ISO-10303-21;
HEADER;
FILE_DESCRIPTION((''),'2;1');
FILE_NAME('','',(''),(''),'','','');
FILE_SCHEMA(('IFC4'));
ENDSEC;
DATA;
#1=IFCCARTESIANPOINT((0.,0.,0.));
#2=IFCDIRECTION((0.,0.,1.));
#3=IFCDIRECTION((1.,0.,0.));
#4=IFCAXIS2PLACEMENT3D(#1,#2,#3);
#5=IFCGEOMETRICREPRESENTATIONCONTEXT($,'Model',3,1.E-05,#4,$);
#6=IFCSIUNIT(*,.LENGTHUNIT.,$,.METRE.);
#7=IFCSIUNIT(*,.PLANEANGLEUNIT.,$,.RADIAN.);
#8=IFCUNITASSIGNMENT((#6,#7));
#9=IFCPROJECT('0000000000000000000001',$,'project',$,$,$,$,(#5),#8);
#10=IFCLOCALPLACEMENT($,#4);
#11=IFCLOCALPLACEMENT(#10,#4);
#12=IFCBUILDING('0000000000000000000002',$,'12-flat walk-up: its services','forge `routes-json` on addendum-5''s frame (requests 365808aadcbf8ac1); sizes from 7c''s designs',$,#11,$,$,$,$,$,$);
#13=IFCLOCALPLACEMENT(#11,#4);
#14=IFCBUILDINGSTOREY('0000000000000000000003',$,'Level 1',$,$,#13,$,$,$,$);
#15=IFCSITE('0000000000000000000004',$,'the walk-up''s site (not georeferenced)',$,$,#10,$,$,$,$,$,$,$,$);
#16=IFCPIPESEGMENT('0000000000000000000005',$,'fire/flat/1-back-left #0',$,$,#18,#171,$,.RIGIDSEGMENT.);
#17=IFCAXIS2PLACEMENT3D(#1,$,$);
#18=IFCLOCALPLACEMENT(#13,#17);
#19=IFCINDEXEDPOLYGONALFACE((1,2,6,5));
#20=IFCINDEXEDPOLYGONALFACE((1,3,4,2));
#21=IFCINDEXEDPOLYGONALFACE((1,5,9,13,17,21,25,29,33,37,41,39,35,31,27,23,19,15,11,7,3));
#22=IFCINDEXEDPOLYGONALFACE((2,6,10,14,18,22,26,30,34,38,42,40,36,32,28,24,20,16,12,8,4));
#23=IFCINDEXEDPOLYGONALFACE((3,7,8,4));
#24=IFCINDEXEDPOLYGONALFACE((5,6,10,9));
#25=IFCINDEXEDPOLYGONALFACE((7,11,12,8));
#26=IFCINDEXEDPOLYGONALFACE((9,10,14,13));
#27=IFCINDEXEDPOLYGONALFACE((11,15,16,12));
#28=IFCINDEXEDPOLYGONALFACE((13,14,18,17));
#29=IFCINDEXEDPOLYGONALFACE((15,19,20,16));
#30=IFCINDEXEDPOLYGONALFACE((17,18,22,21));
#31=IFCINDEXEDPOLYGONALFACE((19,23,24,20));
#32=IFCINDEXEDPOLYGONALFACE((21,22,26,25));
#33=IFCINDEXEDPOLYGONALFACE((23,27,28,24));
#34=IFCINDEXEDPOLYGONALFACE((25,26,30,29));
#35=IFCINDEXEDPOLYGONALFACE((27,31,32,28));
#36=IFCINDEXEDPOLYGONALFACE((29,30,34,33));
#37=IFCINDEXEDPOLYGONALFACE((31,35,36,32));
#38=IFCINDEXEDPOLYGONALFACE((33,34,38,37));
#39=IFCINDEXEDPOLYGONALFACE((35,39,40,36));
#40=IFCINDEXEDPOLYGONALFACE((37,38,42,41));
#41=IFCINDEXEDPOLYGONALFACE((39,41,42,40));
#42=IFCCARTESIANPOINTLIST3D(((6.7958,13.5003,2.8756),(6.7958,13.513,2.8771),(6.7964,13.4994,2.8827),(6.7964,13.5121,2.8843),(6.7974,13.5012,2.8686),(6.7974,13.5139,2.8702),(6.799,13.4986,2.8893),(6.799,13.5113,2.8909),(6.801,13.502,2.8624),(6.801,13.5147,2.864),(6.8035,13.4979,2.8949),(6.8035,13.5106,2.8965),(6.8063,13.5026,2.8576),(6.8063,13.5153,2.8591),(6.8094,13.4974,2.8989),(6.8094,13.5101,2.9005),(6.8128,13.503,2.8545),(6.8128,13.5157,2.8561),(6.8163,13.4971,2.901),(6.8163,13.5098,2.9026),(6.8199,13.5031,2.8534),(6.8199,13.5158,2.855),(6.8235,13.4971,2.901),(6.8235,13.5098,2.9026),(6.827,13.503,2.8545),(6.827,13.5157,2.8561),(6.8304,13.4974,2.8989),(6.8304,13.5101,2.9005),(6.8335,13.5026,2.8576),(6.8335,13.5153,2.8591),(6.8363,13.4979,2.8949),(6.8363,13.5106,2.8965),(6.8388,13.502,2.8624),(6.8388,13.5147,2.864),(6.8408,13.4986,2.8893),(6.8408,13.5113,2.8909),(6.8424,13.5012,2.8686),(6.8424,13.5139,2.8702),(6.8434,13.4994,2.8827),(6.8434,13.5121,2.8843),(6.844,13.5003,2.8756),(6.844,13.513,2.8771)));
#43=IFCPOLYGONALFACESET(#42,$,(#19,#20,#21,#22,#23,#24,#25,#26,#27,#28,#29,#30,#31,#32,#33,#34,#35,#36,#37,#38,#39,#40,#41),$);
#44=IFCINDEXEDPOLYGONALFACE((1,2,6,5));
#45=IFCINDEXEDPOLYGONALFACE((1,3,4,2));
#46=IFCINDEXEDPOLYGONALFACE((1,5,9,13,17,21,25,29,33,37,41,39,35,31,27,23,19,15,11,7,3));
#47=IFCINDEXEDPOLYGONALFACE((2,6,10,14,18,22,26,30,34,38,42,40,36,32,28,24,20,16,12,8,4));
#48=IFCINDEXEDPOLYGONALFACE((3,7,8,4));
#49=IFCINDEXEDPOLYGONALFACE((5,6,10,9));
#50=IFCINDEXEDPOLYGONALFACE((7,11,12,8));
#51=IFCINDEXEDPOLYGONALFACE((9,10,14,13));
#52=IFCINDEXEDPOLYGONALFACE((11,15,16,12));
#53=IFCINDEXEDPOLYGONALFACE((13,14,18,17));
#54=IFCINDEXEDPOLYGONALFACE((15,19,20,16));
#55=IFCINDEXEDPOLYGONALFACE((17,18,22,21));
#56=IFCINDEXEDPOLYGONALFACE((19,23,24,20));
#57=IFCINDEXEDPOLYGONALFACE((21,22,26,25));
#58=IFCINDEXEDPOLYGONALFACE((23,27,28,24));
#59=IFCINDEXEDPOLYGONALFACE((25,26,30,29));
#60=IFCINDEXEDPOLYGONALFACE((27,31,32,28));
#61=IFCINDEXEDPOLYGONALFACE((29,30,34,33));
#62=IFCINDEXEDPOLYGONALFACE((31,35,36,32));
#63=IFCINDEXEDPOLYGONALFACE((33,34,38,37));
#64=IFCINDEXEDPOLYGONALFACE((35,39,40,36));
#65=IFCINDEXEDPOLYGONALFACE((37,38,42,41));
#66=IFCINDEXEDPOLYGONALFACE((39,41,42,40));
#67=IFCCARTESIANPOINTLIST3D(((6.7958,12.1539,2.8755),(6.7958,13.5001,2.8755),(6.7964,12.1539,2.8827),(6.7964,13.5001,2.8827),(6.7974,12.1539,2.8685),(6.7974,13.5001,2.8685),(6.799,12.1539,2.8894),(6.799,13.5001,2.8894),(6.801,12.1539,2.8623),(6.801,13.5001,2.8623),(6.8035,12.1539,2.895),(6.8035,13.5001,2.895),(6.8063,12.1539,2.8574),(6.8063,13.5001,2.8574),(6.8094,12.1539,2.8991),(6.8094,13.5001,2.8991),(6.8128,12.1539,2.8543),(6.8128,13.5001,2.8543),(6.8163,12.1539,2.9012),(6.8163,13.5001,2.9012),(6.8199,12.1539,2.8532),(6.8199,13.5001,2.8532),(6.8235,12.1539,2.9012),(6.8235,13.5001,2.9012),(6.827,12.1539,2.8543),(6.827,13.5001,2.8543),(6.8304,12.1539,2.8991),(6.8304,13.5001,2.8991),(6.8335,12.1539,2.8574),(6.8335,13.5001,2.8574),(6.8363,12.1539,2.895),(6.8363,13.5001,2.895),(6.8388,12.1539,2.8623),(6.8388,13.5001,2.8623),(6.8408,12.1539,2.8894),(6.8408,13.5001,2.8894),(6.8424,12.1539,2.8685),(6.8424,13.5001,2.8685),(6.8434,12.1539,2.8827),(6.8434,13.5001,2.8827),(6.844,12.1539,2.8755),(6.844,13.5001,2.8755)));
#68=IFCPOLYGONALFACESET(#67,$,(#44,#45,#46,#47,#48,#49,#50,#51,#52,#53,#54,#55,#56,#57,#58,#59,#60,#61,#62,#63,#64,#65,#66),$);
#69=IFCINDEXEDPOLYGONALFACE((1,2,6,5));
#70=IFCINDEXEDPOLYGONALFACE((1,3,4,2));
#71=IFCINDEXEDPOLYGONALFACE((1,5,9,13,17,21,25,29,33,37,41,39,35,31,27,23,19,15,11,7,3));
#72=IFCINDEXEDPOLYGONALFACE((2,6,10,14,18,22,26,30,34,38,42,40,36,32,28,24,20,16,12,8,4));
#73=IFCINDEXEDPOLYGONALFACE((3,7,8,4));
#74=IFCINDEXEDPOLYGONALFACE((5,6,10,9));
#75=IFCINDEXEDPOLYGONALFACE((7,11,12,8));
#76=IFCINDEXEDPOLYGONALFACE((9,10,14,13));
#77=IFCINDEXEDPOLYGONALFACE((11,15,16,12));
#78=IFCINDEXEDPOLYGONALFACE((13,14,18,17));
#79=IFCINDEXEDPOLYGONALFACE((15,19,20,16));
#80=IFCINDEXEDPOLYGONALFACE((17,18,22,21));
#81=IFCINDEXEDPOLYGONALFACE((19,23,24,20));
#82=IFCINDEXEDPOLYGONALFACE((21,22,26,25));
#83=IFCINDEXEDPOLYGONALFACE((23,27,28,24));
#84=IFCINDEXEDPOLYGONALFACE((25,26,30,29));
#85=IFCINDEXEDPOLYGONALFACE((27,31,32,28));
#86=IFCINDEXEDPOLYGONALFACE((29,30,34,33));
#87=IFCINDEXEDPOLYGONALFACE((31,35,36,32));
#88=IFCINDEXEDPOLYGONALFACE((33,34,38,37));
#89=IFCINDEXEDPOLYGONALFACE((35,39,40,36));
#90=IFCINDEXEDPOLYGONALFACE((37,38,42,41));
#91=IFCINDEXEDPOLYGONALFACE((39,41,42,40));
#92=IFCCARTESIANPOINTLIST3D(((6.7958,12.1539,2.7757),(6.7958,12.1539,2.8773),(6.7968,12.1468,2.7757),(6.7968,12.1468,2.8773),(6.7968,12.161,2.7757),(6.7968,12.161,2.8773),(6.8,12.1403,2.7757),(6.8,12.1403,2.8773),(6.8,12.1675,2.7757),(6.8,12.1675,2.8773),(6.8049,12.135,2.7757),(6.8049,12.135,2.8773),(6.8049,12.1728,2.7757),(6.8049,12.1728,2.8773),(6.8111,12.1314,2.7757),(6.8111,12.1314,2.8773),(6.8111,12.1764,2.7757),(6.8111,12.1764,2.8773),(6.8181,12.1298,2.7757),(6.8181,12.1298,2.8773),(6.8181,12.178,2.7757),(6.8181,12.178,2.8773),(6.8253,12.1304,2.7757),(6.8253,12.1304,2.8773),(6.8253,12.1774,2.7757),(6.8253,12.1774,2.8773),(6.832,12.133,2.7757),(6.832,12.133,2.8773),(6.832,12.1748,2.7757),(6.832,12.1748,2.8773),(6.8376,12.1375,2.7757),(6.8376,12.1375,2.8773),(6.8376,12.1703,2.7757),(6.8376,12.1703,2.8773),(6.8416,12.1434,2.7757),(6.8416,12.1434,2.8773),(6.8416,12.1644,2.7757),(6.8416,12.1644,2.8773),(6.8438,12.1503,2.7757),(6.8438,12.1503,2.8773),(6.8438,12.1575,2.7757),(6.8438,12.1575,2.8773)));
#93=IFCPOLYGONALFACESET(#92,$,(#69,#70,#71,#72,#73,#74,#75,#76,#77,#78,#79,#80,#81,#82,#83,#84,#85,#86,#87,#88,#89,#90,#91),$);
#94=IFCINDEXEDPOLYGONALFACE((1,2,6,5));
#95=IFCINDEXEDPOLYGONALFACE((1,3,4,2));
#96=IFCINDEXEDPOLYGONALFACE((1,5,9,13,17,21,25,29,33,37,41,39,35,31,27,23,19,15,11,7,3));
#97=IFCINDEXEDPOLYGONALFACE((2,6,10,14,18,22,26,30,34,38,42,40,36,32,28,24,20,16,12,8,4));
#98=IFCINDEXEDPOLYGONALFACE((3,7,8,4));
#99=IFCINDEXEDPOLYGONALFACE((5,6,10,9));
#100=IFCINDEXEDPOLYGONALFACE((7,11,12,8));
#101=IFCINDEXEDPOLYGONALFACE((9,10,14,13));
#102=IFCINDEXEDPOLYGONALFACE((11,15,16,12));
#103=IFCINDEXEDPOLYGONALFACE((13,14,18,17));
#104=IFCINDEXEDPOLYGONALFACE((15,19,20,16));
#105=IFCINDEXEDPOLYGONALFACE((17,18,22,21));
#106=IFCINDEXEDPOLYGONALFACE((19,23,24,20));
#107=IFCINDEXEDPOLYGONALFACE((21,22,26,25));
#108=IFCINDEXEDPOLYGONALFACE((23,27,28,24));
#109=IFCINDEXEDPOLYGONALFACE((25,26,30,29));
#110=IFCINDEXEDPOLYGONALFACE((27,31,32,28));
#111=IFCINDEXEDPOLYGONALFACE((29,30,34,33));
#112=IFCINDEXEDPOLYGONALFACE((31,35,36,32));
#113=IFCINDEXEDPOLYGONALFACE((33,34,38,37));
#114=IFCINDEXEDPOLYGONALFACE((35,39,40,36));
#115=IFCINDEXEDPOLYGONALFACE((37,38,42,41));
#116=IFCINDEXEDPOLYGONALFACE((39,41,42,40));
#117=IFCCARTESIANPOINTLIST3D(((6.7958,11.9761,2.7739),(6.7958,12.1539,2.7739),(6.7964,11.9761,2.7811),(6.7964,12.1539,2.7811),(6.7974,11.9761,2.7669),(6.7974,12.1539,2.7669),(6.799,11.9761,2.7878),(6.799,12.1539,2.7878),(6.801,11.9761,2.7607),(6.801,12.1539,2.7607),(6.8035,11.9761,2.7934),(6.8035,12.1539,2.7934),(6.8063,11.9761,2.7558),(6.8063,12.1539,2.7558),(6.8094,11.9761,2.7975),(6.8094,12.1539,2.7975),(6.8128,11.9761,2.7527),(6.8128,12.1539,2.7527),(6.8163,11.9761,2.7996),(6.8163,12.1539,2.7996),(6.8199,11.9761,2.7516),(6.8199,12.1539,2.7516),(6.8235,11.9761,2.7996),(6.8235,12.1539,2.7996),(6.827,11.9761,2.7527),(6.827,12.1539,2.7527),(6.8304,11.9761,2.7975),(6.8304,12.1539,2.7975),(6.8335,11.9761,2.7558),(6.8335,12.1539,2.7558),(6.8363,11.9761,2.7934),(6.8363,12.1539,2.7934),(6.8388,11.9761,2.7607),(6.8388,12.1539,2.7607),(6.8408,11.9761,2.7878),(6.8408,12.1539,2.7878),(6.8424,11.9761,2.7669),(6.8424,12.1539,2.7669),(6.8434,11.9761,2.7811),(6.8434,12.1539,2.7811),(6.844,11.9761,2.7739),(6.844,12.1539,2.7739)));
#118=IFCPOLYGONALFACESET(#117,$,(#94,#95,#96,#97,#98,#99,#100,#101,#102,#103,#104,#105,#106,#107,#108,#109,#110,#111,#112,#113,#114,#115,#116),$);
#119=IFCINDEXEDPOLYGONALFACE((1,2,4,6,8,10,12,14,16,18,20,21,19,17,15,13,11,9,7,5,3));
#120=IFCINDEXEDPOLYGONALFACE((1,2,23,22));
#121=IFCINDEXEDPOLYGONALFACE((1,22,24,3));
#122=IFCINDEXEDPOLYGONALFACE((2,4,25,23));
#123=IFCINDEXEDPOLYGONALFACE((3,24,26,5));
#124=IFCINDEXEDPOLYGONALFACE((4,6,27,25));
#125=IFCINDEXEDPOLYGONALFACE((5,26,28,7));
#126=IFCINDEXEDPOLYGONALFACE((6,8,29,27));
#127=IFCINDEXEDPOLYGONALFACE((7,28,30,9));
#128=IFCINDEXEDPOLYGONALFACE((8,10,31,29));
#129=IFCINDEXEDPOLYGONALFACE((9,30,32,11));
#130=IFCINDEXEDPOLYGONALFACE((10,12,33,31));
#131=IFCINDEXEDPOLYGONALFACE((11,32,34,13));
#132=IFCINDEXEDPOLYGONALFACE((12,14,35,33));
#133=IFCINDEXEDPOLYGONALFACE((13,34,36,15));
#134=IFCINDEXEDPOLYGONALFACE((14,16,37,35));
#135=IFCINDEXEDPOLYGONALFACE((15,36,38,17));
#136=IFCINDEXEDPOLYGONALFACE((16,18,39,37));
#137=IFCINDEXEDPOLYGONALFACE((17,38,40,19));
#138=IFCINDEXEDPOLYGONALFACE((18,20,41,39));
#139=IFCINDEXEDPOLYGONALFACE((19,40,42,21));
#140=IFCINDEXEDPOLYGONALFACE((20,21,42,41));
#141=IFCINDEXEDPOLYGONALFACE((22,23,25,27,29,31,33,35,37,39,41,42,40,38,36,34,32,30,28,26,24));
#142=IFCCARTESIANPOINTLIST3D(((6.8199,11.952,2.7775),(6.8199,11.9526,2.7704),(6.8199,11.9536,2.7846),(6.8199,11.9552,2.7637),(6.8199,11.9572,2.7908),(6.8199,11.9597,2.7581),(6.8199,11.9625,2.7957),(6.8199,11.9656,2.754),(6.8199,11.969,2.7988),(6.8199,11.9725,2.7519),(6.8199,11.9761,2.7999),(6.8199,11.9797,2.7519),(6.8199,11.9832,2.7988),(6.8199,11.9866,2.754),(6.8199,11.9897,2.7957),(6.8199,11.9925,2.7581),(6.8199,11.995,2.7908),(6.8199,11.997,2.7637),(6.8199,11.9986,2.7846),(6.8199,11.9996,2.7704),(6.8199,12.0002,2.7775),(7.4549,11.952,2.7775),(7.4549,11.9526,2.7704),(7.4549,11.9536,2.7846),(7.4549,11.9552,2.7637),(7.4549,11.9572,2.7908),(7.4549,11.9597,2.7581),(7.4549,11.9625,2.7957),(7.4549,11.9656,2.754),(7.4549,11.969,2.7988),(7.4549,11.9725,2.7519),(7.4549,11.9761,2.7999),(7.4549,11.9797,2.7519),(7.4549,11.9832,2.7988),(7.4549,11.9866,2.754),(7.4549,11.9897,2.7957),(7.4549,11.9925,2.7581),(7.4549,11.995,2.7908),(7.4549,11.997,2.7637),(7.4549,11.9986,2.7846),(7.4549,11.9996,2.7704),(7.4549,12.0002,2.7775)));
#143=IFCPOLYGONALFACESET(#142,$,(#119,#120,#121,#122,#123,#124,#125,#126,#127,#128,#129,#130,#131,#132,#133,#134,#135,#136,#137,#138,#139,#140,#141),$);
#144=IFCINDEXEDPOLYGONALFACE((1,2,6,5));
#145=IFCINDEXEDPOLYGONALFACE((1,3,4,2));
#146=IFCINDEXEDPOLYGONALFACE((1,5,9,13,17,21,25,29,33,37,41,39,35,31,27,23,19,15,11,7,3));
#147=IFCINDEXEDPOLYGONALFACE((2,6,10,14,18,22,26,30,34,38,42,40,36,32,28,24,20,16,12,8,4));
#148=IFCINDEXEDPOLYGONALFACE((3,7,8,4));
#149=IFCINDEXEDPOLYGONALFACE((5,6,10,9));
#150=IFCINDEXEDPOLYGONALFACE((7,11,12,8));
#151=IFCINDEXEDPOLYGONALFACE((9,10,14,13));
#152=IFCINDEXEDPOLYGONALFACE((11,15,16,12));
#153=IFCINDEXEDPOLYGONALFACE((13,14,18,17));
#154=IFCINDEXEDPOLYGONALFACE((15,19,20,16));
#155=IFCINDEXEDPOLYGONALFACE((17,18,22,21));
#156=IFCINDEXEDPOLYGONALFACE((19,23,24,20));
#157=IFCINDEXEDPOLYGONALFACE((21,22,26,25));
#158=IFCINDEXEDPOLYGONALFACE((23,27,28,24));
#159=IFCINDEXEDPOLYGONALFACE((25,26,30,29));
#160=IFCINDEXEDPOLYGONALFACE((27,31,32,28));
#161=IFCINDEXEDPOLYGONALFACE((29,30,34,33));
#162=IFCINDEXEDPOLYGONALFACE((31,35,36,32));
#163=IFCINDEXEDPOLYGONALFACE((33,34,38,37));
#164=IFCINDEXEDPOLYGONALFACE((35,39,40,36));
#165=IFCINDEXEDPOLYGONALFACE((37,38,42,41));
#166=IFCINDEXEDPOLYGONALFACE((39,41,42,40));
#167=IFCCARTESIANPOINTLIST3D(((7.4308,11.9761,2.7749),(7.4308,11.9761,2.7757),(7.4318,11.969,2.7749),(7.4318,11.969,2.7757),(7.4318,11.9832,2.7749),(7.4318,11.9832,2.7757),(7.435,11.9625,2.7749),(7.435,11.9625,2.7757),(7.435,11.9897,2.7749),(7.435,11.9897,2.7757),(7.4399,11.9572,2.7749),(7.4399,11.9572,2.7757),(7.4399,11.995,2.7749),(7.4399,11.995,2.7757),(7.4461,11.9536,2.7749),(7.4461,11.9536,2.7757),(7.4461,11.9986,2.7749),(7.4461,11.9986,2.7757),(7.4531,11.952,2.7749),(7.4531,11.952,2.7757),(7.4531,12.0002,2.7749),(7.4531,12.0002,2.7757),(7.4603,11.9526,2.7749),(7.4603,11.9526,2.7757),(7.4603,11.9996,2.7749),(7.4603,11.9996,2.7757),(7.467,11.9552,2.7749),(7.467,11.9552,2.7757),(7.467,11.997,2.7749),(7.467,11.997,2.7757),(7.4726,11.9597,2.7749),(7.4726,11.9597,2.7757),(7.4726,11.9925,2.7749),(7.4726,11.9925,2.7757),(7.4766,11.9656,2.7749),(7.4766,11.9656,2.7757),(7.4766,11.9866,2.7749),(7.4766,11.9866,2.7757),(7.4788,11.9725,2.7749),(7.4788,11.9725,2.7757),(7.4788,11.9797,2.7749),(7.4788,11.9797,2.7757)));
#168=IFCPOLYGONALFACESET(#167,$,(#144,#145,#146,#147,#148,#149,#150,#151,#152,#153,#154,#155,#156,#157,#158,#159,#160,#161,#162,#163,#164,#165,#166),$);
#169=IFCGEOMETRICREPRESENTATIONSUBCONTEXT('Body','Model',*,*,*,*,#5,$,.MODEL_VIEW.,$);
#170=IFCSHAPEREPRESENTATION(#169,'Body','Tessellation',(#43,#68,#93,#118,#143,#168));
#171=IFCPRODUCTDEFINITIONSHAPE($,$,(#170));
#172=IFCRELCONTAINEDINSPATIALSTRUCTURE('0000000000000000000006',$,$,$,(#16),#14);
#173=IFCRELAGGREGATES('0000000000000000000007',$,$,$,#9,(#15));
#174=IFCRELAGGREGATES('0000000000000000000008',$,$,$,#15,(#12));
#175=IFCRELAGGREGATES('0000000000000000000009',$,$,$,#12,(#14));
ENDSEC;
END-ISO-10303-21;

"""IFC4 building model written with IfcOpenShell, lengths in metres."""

from ifc_helpers import new_model, entity, si_unit, frame, origin_with_axes, place, context, subcontext, project, spatial, element, save


model = new_model("IFC4")

# Units and contexts
model_context = context("Model", 3, precision=1e-05, world=origin_with_axes())
body_context = subcontext(model_context, "Body", "Model", "MODEL_VIEW")
ifc_project = project(units=[si_unit("LENGTHUNIT", "METRE"), si_unit("PLANEANGLEUNIT", "RADIAN")], contexts=[model_context])

# Site, building, storey
site_placement = place(None, origin_with_axes())
site = spatial("IfcSite", under=ifc_project, at=site_placement, Name="the walk-up's site (not georeferenced)")
building_placement = place(site_placement, origin_with_axes())
building = spatial("IfcBuilding", under=site, at=building_placement, Name="12-flat walk-up: its services", Description="forge `routes-json` on addendum-5's frame (requests 365808aadcbf8ac1); sizes from 7c's designs")
storey_placement = place(building_placement, origin_with_axes())
storey = spatial("IfcBuildingStorey", under=building, at=storey_placement, Name="Level 1")

# Pipe segment
pipe_segment_1_placement = place(storey_placement, frame((6.8199, 13.5128, 2.8789), z_axis=(0.0, 0.0, 1.0), x_axis=(1.0, 0.0, 0.0)))
element("IfcPipeSegment", 1, at=pipe_segment_1_placement, inside=storey, Name="fire/flat/1-back-left #0", PredefinedType="RIGIDSEGMENT", context=body_context, shape_type="AdvancedSweptSolid", body=[
    entity("IfcSweptDiskSolid", entity("IfcPolyline", [entity("IfcCartesianPoint", [0.0, 0.0, 0.0]), entity("IfcCartesianPoint", [0.0, -0.0127, -0.0016])]), 0.0241),
    entity("IfcSweptDiskSolid", entity("IfcPolyline", [entity("IfcCartesianPoint", [0.0, -0.0127, -0.0016]), entity("IfcCartesianPoint", [0.0, -1.3589, -0.0016])]), 0.0241),
    entity("IfcSweptDiskSolid", entity("IfcPolyline", [entity("IfcCartesianPoint", [0.0, -1.3589, -0.0016]), entity("IfcCartesianPoint", [0.0, -1.3589, -0.1032])]), 0.0241),
    entity("IfcSweptDiskSolid", entity("IfcPolyline", [entity("IfcCartesianPoint", [0.0, -1.3589, -0.1032]), entity("IfcCartesianPoint", [0.0, -1.5367, -0.1032])]), 0.0241),
    entity("IfcSweptDiskSolid", entity("IfcPolyline", [entity("IfcCartesianPoint", [0.0, -1.5367, -0.1032]), entity("IfcCartesianPoint", [0.635, -1.5367, -0.1032])]), 0.0241),
    entity("IfcSweptDiskSolid", entity("IfcPolyline", [entity("IfcCartesianPoint", [0.635, -1.5367, -0.1032]), entity("IfcCartesianPoint", [0.635, -1.5367, -0.104])]), 0.0241),
])

save(model, "model.ifc")
